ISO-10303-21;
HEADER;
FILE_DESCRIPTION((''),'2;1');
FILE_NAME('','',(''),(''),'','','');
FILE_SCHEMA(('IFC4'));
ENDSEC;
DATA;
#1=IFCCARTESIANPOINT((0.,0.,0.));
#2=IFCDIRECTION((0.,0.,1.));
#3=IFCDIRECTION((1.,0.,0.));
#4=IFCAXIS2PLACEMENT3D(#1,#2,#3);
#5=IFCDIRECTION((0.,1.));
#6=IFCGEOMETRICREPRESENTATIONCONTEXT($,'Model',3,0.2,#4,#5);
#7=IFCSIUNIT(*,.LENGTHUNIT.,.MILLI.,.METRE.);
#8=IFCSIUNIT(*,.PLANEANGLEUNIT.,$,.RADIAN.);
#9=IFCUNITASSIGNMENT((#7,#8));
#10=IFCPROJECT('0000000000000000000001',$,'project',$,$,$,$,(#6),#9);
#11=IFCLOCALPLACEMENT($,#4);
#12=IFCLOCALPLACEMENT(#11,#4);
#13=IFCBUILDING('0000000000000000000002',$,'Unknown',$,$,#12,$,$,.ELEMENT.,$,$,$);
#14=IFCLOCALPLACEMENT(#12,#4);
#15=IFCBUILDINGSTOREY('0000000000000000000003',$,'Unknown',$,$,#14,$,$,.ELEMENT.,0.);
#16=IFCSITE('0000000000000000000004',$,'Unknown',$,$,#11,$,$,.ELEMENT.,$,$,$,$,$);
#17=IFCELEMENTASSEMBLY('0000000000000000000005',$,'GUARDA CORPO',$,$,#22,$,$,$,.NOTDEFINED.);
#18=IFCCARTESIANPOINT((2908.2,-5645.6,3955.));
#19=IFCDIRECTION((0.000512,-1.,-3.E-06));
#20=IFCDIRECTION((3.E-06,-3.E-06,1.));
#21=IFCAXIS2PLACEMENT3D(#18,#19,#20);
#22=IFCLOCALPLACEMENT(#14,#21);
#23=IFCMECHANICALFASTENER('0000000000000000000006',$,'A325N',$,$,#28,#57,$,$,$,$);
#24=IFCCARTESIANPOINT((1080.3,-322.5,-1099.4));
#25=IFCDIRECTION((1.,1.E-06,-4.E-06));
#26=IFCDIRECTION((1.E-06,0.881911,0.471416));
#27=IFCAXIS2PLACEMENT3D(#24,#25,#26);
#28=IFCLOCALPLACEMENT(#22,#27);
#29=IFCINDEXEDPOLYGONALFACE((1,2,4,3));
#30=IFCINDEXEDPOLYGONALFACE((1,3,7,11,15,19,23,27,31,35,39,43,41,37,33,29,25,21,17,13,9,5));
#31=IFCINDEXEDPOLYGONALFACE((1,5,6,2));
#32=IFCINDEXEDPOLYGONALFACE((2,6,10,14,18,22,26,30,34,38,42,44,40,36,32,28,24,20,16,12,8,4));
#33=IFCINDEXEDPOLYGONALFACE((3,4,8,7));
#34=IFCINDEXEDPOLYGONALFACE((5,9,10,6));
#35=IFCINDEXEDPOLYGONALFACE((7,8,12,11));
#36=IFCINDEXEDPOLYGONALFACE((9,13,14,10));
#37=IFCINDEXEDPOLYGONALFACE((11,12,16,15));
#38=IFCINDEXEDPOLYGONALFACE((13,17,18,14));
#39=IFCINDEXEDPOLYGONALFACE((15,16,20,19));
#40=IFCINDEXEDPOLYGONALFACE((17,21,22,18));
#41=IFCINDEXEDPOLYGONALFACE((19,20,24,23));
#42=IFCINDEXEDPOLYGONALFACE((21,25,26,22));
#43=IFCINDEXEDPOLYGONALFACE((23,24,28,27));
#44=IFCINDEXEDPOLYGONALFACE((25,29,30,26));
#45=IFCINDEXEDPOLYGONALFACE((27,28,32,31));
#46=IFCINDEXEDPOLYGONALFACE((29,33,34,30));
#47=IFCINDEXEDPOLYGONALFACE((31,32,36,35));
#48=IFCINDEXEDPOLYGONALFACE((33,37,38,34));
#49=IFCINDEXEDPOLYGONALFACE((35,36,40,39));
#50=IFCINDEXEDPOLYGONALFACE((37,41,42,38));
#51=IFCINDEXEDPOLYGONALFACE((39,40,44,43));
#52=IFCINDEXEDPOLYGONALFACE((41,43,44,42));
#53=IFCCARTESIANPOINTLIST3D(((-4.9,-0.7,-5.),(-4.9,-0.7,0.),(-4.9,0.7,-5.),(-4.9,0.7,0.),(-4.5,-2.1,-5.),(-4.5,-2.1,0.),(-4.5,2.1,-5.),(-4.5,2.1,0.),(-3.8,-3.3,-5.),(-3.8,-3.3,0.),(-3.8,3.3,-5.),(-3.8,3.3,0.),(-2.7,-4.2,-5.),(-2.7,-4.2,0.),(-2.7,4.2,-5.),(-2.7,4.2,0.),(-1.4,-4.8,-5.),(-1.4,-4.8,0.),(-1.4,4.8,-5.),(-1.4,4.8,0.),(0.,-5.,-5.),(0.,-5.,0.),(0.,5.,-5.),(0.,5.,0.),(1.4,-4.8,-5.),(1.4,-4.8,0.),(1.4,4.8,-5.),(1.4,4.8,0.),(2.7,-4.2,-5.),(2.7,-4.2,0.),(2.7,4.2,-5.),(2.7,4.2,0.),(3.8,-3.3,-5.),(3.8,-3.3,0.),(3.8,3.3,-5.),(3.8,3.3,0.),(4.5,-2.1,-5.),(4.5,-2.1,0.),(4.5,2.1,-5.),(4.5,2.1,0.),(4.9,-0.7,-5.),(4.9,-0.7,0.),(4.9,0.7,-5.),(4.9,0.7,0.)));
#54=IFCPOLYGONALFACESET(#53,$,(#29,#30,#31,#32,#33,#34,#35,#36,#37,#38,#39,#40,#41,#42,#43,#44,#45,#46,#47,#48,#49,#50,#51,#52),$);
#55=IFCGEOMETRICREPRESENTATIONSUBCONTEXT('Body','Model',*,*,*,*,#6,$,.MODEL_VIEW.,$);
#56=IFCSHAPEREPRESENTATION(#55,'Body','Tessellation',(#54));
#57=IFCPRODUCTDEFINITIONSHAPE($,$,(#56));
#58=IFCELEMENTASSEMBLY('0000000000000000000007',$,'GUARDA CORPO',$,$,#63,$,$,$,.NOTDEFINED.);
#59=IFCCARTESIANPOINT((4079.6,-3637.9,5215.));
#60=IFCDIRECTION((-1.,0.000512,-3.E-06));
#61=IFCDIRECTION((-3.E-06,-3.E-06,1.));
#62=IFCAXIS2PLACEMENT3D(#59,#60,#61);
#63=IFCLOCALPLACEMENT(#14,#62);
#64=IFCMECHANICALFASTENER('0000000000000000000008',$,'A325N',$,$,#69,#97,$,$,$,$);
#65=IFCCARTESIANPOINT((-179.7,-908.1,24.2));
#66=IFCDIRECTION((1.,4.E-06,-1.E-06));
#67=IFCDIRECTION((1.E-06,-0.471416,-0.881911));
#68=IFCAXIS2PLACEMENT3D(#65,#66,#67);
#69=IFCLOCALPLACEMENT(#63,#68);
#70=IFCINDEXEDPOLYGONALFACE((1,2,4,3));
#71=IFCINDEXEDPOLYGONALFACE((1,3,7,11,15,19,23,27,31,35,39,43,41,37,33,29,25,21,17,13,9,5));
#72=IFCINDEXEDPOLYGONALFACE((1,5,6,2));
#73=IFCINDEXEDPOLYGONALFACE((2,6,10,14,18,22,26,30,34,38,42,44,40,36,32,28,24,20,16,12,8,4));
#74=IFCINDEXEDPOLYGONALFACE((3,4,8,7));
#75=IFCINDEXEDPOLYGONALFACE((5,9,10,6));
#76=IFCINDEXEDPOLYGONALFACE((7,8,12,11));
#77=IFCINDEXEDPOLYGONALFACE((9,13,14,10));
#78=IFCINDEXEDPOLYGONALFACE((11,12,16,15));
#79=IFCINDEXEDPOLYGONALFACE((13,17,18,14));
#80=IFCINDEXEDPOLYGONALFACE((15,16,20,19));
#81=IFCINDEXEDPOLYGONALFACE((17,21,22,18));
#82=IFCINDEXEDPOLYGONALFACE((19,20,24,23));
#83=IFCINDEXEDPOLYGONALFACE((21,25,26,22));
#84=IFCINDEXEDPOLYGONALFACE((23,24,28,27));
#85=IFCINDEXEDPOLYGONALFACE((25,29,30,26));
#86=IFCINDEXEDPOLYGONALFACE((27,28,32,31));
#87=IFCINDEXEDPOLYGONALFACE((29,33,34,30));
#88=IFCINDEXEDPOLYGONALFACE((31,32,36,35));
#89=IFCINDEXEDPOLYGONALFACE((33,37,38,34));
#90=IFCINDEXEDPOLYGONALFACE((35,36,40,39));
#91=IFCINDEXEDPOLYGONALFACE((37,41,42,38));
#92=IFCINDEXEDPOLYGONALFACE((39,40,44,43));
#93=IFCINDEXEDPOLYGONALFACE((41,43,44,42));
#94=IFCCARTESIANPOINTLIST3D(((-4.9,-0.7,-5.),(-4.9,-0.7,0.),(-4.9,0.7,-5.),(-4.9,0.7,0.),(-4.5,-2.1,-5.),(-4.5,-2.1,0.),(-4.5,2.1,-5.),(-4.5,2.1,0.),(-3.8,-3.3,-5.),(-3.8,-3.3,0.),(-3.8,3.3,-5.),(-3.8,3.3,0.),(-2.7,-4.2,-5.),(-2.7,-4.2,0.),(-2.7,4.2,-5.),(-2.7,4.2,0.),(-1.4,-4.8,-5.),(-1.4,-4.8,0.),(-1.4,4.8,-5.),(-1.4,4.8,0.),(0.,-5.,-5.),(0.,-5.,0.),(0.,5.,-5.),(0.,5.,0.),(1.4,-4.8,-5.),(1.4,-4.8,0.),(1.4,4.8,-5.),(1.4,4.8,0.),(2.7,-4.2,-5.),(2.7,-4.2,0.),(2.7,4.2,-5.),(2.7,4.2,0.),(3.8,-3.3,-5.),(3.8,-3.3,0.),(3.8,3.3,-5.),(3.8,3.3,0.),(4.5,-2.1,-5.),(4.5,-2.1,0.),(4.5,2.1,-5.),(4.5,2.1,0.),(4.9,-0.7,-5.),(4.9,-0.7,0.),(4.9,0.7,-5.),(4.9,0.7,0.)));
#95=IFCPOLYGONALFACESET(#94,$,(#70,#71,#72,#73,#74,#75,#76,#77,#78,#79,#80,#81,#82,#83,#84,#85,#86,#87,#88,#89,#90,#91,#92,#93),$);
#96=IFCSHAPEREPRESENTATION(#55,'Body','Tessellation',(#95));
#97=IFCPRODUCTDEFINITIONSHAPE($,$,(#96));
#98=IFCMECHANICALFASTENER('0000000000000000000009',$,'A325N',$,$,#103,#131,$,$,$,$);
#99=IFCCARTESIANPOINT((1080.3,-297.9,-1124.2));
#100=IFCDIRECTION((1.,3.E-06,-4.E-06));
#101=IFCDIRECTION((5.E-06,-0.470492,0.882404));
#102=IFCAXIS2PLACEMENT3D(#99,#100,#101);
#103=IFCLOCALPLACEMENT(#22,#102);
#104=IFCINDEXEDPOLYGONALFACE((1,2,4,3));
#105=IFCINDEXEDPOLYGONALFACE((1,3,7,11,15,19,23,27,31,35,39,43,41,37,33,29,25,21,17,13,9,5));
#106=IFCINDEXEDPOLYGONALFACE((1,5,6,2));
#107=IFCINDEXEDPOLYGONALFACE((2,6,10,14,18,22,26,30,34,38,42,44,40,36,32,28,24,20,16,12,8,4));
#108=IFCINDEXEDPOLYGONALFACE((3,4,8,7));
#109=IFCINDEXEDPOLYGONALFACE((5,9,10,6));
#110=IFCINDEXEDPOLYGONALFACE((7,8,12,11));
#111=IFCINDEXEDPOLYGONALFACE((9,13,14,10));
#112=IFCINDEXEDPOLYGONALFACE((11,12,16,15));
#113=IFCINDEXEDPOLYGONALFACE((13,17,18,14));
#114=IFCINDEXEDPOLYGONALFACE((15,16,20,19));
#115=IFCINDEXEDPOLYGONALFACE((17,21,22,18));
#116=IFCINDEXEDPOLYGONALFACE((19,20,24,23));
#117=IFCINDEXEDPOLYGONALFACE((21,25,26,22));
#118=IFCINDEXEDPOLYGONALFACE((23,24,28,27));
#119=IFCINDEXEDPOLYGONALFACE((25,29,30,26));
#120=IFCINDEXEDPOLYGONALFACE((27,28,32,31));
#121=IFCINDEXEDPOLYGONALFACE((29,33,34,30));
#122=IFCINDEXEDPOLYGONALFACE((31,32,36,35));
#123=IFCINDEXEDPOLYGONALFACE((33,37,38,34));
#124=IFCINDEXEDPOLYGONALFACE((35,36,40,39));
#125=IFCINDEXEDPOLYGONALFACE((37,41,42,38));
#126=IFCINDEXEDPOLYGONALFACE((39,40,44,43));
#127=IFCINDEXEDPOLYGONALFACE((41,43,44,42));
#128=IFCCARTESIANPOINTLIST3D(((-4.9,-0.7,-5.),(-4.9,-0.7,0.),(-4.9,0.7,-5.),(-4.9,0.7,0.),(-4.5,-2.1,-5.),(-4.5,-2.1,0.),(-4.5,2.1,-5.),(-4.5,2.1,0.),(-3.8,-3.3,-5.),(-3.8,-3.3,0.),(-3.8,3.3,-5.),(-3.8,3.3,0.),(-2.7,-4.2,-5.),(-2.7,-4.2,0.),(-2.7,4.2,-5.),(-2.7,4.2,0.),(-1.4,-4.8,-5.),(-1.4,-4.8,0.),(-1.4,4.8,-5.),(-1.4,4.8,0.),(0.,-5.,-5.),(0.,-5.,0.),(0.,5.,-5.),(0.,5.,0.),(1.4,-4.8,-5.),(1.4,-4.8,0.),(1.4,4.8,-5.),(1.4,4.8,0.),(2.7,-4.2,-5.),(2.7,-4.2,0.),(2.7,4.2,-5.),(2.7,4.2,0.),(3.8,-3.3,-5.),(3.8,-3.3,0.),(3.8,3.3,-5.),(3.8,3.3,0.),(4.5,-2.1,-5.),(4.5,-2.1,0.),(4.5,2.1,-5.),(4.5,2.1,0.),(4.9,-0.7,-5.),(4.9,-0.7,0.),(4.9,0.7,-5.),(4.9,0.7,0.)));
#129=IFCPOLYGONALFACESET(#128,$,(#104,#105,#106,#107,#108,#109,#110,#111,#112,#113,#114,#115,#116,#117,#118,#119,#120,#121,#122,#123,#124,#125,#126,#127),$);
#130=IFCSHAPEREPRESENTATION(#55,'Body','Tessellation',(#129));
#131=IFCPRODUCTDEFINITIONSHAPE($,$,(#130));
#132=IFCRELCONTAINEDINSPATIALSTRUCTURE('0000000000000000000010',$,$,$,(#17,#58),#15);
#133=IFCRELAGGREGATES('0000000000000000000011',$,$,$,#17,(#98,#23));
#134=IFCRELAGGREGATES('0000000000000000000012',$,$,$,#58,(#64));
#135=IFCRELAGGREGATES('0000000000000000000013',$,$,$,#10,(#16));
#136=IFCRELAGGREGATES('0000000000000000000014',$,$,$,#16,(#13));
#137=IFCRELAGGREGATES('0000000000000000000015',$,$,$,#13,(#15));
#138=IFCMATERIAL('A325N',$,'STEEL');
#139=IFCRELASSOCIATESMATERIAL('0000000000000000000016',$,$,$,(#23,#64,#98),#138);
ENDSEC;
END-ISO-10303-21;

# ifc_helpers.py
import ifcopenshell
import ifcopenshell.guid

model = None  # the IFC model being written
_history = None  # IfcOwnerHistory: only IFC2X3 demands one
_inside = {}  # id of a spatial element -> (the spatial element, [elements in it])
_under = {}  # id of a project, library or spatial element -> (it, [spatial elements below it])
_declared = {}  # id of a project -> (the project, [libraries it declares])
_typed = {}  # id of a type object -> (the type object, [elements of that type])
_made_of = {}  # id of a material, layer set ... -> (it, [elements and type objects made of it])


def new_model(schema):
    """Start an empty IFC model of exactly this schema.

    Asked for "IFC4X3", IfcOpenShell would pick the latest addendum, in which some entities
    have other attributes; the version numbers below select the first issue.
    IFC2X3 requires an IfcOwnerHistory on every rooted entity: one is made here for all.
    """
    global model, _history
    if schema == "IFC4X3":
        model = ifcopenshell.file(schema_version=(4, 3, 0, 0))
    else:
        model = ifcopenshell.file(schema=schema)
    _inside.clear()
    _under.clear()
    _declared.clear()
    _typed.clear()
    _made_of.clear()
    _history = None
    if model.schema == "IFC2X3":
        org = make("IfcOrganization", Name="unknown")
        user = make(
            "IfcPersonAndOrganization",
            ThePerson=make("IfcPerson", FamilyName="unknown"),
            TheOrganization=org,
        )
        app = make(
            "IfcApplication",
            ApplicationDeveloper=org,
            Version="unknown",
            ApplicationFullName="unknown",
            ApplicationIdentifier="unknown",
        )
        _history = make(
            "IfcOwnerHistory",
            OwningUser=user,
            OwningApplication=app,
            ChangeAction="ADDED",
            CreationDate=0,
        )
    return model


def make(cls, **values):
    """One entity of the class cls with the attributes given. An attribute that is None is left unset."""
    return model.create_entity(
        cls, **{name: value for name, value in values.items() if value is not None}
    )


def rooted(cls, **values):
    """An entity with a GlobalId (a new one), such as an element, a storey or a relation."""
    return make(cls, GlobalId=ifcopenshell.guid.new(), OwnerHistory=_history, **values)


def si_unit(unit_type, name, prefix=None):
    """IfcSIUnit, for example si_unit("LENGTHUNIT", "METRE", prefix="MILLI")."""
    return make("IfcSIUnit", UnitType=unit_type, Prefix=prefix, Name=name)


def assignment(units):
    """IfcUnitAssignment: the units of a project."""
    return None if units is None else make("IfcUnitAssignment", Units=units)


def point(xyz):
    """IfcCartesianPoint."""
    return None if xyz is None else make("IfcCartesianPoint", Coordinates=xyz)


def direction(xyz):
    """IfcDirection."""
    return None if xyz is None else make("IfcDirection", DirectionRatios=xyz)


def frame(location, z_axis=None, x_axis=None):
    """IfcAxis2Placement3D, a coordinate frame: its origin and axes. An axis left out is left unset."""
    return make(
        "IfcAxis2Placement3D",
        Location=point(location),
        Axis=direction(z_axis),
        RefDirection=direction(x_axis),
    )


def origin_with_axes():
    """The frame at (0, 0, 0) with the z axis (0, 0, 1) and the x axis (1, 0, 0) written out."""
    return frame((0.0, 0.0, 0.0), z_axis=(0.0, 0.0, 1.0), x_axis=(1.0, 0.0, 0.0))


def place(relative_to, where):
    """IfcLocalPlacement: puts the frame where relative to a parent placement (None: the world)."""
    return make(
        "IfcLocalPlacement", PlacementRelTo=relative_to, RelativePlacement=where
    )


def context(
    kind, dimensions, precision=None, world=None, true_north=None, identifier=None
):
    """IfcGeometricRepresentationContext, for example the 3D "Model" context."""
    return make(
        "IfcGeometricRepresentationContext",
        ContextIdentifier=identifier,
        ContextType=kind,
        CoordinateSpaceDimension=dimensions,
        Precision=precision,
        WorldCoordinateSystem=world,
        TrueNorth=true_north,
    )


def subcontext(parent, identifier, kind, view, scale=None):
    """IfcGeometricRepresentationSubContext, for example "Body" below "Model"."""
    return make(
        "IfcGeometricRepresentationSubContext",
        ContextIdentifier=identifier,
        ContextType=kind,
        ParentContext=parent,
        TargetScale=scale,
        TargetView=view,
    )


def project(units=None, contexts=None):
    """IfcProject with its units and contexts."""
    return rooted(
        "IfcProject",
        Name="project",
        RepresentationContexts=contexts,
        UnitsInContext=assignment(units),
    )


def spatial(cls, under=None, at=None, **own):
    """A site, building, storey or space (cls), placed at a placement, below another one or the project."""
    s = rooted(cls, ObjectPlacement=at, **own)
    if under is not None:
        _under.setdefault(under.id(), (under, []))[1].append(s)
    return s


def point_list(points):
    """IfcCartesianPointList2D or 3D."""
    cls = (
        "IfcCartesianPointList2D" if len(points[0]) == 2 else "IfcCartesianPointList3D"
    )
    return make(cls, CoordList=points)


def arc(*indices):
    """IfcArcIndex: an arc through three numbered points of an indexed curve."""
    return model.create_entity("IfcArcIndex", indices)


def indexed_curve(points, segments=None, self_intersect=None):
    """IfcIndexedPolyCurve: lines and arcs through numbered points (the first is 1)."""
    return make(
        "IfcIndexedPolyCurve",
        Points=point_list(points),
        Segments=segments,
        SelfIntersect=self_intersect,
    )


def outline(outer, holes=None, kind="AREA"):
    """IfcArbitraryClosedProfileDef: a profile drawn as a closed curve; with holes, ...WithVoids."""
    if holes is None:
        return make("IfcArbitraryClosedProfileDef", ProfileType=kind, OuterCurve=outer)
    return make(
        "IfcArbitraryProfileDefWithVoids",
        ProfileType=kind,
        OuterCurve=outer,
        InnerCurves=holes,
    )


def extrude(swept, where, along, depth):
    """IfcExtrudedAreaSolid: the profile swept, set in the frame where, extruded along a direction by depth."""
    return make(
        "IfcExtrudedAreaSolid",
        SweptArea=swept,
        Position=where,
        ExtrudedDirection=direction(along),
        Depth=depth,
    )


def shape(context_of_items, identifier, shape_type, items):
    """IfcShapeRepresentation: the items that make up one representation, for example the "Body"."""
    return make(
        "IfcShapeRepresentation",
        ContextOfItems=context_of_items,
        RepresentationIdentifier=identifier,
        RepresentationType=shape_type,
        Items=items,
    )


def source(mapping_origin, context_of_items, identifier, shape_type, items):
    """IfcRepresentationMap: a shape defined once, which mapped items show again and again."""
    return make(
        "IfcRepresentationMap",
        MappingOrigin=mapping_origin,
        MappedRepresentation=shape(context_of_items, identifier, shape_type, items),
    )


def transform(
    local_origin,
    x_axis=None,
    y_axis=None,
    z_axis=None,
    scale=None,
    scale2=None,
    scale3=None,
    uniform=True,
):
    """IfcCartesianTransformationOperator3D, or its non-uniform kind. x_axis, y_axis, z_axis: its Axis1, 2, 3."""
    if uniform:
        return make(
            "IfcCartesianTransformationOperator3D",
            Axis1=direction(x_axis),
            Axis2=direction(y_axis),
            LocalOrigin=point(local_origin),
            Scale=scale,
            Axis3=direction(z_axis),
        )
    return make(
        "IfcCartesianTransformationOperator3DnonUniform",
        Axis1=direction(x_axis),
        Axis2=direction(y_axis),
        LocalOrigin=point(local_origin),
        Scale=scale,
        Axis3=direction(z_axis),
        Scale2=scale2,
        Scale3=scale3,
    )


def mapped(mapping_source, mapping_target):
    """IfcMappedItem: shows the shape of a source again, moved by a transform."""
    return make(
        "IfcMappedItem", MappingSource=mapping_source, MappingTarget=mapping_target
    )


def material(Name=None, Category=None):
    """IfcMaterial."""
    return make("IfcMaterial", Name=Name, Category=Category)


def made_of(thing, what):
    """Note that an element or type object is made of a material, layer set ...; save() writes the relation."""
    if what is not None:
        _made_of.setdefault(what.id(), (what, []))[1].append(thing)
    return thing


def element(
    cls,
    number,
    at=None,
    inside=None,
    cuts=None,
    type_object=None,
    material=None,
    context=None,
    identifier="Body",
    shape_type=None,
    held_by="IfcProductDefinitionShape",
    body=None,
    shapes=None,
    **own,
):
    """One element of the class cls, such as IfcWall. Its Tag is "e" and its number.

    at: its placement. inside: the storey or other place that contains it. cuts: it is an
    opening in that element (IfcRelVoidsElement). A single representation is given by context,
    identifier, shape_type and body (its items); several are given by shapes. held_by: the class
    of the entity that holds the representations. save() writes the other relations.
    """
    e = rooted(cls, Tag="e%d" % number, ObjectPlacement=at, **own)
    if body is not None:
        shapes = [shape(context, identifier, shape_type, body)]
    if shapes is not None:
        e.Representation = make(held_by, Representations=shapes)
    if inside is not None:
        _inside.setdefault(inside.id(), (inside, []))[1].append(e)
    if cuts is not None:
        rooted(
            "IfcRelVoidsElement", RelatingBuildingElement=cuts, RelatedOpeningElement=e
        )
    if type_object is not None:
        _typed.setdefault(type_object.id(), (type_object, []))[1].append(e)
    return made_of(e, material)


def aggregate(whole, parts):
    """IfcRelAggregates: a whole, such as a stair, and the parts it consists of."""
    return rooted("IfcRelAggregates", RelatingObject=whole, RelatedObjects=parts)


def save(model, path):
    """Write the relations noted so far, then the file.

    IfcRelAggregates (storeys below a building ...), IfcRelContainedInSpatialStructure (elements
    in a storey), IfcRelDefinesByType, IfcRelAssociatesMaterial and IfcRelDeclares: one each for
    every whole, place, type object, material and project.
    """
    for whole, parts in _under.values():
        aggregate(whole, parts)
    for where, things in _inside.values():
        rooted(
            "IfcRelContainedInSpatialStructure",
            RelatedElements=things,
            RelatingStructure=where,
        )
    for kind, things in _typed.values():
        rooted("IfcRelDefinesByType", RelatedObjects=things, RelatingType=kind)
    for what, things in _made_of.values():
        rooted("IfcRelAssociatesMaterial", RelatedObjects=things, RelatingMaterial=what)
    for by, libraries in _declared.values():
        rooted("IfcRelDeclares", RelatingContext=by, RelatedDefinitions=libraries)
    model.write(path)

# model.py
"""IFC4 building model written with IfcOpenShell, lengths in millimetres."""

from ifc_helpers import new_model, si_unit, direction, frame, origin_with_axes, place, context, subcontext, project, spatial, arc, indexed_curve, outline, extrude, source, transform, mapped, material, element, aggregate, save


model = new_model("IFC4")

# Units and contexts
model_context = context("Model", 3, precision=0.2, world=origin_with_axes(), true_north=direction((0.0, 1.0)))
body_context = subcontext(model_context, "Body", "Model", "MODEL_VIEW")
ifc_project = project(units=[si_unit("LENGTHUNIT", "METRE", prefix="MILLI"), si_unit("PLANEANGLEUNIT", "RADIAN")], contexts=[model_context])

# Site, building, storey
site_placement = place(None, origin_with_axes())
site = spatial("IfcSite", under=ifc_project, at=site_placement, Name="Unknown", CompositionType="ELEMENT")
building_placement = place(site_placement, origin_with_axes())
building = spatial("IfcBuilding", under=site, at=building_placement, Name="Unknown", CompositionType="ELEMENT")
storey_placement = place(building_placement, origin_with_axes())
storey = spatial("IfcBuildingStorey", under=building, at=storey_placement, Name="Unknown", CompositionType="ELEMENT", Elevation=0.0)

# Element assembly
assembly_1_placement = place(storey_placement, frame((2908.2, -5645.6, 3955.0), z_axis=(0.000512, -1.0, -0.000003), x_axis=(0.000003, -0.000003, 1.0)))
assembly_1 = element("IfcElementAssembly", 1, at=assembly_1_placement, inside=storey, Name="GUARDA CORPO", PredefinedType="NOTDEFINED")

# Shared definitions
ifc_material_1 = material(Name="A325N", Category="STEEL")

# Mechanical fastener
shared_shape_1 = source(origin_with_axes(), body_context, "Body", "SweptSolid", [
    extrude(outline(indexed_curve([(5.0, 0.0), (0.0, 5.0), (-5.0, 0.0), (0.0, -5.0)], segments=[arc(1, 2, 3), arc(3, 4, 1)])), frame((0.0, 0.0, 0.0), z_axis=(0.0, 0.0, -1.0), x_axis=(0.0, 1.0, 0.0)), (0.0, 0.0, 1.0), 5.0),
])
mechanical_fastener_1_placement = place(assembly_1_placement, frame((1080.3, -322.5, -1099.4), z_axis=(1.0, 0.000001, -0.000004), x_axis=(0.000001, 0.881911, 0.471416)))
mechanical_fastener_1 = element("IfcMechanicalFastener", 2, at=mechanical_fastener_1_placement, material=ifc_material_1, Name="A325N", context=body_context, shape_type="MappedRepresentation", body=[
    mapped(shared_shape_1, transform((0.0, 0.0, 0.0))),
])

# Element assembly, mechanical fastener
assembly_2_placement = place(storey_placement, frame((4079.6, -3637.9, 5215.0), z_axis=(-1.0, 0.000512, -0.000003), x_axis=(-0.000003, -0.000003, 1.0)))
assembly_2 = element("IfcElementAssembly", 3, at=assembly_2_placement, inside=storey, Name="GUARDA CORPO", PredefinedType="NOTDEFINED")
mechanical_fastener_2_placement = place(assembly_2_placement, frame((-179.7, -908.1, 24.2), z_axis=(1.0, 0.000004, -0.000001), x_axis=(0.000001, -0.471416, -0.881911)))
mechanical_fastener_2 = element("IfcMechanicalFastener", 4, at=mechanical_fastener_2_placement, material=ifc_material_1, Name="A325N", context=body_context, shape_type="MappedRepresentation", body=[
    mapped(shared_shape_1, transform((0.0, 0.0, 0.0))),
])

# Mechanical fastener
shared_shape_2 = source(origin_with_axes(), body_context, "Body", "SweptSolid", [
    extrude(outline(indexed_curve([(5.0, 0.0), (0.0, 5.0), (-5.0, 0.0), (0.0, -5.0)], segments=[arc(1, 2, 3), arc(3, 4, 1)])), frame((0.0, 0.0, 0.0), z_axis=(0.0, 0.0, -1.0), x_axis=(0.0, 1.0, 0.0)), (0.0, 0.0, 1.0), 5.0),
])
mechanical_fastener_3_placement = place(assembly_1_placement, frame((1080.3, -297.9, -1124.2), z_axis=(1.0, 0.000003, -0.000004), x_axis=(0.000005, -0.470492, 0.882404)))
mechanical_fastener_3 = element("IfcMechanicalFastener", 5, at=mechanical_fastener_3_placement, material=ifc_material_1, Name="A325N", context=body_context, shape_type="MappedRepresentation", body=[
    mapped(shared_shape_2, transform((0.0, 0.0, 0.0))),
])
aggregate(assembly_1, [mechanical_fastener_3, mechanical_fastener_1])
aggregate(assembly_2, [mechanical_fastener_2])

save(model, "model.ifc")
